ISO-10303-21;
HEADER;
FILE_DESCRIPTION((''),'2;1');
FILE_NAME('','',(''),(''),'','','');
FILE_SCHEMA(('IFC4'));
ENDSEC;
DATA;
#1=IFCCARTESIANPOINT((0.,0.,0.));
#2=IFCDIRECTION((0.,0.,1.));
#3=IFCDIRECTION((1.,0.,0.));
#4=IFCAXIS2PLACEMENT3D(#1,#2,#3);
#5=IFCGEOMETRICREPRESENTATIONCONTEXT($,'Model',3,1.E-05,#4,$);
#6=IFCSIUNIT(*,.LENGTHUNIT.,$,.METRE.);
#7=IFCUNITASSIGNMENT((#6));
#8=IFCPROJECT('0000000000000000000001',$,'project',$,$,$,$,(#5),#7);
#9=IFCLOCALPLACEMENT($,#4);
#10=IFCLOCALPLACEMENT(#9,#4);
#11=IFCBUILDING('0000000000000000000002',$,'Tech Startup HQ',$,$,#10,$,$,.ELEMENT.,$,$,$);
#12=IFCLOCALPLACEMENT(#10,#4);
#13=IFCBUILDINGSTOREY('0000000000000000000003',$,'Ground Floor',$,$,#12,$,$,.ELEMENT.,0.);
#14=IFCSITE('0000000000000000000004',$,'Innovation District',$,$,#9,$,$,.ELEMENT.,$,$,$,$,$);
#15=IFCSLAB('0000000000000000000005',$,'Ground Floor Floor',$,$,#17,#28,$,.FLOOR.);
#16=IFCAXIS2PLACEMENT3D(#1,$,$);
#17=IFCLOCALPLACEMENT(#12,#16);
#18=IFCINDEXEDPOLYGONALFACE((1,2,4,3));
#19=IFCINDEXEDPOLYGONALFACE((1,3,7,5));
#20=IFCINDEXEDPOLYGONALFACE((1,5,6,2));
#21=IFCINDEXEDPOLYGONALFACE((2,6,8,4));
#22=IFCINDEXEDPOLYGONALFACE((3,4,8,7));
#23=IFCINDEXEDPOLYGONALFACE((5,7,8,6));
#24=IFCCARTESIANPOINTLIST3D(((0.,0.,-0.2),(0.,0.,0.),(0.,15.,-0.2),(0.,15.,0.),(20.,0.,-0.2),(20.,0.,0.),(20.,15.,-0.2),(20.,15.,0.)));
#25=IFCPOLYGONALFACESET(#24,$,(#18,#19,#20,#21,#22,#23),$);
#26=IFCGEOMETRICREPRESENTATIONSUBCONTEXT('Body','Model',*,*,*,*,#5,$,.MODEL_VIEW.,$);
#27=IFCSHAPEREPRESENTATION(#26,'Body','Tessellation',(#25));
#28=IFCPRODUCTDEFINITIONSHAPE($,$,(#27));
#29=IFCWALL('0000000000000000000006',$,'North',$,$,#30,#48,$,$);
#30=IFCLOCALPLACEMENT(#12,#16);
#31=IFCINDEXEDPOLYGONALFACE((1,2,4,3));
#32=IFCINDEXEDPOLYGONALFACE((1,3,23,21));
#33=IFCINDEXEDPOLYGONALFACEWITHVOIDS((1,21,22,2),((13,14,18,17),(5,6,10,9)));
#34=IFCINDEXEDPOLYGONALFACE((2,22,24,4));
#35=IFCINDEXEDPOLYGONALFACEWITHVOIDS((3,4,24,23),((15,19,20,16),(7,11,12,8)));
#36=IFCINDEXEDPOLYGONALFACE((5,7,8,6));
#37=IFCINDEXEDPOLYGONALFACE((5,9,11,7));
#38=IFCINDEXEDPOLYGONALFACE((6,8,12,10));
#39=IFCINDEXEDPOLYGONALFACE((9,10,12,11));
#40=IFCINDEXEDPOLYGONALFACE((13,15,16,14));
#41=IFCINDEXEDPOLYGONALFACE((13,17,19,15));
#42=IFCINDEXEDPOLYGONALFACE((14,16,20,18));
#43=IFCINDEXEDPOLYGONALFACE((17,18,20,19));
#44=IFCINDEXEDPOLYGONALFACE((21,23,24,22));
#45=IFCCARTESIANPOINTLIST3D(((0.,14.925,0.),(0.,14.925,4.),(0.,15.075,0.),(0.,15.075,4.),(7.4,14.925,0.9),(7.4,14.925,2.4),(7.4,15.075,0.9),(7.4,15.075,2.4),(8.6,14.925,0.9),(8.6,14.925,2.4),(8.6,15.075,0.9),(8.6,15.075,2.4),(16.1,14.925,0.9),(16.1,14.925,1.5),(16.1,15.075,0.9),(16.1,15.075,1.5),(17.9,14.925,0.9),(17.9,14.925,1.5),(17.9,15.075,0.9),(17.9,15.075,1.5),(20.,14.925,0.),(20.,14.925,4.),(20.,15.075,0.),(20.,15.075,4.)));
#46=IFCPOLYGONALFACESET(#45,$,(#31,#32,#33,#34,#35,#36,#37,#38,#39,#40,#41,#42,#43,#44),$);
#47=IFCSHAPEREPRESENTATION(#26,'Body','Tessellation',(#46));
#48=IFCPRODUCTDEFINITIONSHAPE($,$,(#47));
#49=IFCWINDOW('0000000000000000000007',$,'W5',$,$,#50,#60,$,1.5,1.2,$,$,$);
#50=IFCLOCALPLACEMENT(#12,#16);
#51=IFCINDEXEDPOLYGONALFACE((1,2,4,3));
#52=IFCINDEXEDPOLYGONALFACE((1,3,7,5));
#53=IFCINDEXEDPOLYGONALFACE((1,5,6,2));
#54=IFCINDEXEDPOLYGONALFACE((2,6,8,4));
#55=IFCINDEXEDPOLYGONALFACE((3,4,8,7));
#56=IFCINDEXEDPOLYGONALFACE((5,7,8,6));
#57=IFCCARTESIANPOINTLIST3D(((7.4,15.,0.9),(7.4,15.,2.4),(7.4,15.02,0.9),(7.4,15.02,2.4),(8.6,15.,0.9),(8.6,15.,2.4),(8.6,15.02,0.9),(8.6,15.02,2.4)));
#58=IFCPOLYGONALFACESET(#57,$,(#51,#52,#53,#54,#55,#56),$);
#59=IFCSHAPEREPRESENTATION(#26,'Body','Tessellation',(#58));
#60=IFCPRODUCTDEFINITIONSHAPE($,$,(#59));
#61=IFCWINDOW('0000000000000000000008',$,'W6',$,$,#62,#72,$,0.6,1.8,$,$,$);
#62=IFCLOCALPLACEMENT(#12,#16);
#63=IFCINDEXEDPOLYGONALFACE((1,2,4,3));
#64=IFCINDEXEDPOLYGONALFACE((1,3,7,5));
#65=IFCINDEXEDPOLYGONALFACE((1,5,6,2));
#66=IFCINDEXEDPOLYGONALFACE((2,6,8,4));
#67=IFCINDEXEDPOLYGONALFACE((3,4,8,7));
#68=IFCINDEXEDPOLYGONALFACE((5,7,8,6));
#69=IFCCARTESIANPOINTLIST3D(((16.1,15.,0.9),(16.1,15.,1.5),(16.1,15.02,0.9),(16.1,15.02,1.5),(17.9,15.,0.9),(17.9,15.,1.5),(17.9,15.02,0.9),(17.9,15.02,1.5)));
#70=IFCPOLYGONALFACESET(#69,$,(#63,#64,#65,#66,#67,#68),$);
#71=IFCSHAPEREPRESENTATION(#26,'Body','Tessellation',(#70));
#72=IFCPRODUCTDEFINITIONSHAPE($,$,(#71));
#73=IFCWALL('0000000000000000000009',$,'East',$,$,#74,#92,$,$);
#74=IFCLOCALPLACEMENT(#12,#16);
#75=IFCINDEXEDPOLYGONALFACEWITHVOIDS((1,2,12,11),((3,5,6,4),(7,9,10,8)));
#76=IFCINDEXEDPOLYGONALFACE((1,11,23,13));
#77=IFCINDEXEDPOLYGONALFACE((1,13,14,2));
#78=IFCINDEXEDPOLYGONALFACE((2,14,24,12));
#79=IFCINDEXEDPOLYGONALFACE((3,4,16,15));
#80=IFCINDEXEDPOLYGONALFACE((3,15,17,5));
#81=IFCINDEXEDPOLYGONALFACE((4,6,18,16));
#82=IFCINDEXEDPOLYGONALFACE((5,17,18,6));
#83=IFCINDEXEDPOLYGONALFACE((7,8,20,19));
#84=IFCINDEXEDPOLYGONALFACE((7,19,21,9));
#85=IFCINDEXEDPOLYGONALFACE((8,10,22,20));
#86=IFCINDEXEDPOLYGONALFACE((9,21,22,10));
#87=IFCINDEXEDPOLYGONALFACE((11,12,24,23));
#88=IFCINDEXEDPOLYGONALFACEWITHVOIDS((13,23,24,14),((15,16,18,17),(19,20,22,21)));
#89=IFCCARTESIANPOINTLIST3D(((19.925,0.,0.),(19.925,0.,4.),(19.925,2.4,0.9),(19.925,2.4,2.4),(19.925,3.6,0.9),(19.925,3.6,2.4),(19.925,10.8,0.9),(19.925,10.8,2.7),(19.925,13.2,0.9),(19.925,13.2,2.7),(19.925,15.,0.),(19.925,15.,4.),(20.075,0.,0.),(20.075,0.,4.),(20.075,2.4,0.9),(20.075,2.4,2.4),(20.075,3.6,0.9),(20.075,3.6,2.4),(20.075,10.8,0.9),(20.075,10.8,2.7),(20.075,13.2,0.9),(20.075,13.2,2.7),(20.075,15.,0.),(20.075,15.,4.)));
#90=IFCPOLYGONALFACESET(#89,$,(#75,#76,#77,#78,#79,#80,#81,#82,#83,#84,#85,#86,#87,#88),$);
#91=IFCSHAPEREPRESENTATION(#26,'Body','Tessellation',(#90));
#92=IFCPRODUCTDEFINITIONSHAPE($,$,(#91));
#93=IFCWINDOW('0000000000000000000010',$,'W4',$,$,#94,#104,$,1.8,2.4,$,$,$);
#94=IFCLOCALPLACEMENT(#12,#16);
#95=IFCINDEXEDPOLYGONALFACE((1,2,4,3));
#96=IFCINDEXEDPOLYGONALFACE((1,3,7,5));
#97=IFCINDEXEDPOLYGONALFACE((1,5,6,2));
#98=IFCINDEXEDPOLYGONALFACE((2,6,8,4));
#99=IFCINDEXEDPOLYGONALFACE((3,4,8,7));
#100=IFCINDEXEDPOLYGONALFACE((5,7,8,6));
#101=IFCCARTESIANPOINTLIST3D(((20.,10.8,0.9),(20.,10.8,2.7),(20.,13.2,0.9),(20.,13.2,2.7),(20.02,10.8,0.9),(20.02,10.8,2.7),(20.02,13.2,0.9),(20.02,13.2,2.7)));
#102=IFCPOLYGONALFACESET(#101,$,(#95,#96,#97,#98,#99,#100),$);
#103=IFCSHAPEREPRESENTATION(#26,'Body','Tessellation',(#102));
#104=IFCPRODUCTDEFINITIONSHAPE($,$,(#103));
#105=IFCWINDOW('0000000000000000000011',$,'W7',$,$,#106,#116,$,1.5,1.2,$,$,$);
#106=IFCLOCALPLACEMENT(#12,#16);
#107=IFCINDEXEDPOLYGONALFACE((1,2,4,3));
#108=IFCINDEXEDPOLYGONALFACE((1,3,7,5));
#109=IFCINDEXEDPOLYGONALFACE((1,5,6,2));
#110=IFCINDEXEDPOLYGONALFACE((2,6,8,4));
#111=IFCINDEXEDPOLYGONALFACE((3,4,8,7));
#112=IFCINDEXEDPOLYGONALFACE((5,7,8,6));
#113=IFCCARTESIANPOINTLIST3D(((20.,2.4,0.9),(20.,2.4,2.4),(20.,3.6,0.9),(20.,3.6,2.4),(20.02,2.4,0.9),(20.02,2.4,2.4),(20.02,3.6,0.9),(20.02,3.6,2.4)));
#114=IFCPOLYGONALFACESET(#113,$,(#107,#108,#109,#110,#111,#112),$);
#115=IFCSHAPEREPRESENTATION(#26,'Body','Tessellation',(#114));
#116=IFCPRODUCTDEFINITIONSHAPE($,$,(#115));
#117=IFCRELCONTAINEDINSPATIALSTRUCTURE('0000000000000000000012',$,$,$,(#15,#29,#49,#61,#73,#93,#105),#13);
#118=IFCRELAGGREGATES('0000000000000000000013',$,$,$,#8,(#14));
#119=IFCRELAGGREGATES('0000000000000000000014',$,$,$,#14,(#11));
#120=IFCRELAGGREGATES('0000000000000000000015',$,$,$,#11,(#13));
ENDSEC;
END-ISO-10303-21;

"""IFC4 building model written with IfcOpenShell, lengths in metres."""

from ifc_helpers import new_model, si_unit, origin_with_axes, place, context, subcontext, project, spatial, polyline, outline, extrude, element, fill, save


model = new_model("IFC4")

# Units and contexts
model_context = context("Model", 3, precision=1e-05, world=origin_with_axes())
body_context = subcontext(model_context, "Body", "Model", "MODEL_VIEW")
ifc_project = project(units=[si_unit("LENGTHUNIT", "METRE")], contexts=[model_context])

# Site, building, storey
site_placement = place(None, origin_with_axes())
site = spatial("IfcSite", under=ifc_project, at=site_placement, Name="Innovation District", CompositionType="ELEMENT")
building_placement = place(site_placement, origin_with_axes())
building = spatial("IfcBuilding", under=site, at=building_placement, Name="Tech Startup HQ", CompositionType="ELEMENT")
storey_placement = place(building_placement, origin_with_axes())
storey = spatial("IfcBuildingStorey", under=building, at=storey_placement, Name="Ground Floor", CompositionType="ELEMENT", Elevation=0.0)

# Slab
slab_placement = place(storey_placement, origin_with_axes())
element("IfcSlab", 1, at=slab_placement, inside=storey, Name="Ground Floor Floor", PredefinedType="FLOOR", context=body_context, shape_type="SweptSolid", body=[
    extrude(outline(polyline([(0.0, 0.0, -0.2), (20.0, 0.0, -0.2), (20.0, 15.0, -0.2), (0.0, 15.0, -0.2), (0.0, 0.0, -0.2)])), None, (0.0, 0.0, 1.0), 0.2),
])

# Walls, openings, windows
wall_1_placement = place(storey_placement, origin_with_axes())
wall_1 = element("IfcWall", 2, at=wall_1_placement, inside=storey, Name="North", context=body_context, shape_type="SweptSolid", body=[
    extrude(outline(polyline([(0.0, 14.925, 0.0), (20.0, 14.925, 0.0), (20.0, 15.075, 0.0), (0.0, 15.075, 0.0), (0.0, 14.925, 0.0)])), None, (0.0, 0.0, 1.0), 4.0),
])
opening_1_placement = place(storey_placement, origin_with_axes())
opening_1 = element("IfcOpeningElement", 3, at=opening_1_placement, inside=storey, cuts=wall_1, context=body_context, shape_type="SweptSolid", body=[
    extrude(outline(polyline([(7.4, 14.85, 0.9), (8.6, 14.85, 0.9), (8.6, 15.15, 0.9), (7.4, 15.15, 0.9), (7.4, 14.85, 0.9)])), None, (0.0, 0.0, 1.0), 1.5),
])
opening_2_placement = place(storey_placement, origin_with_axes())
opening_2 = element("IfcOpeningElement", 4, at=opening_2_placement, inside=storey, cuts=wall_1, context=body_context, shape_type="SweptSolid", body=[
    extrude(outline(polyline([(16.1, 14.85, 0.9), (17.9, 14.85, 0.9), (17.9, 15.15, 0.9), (16.1, 15.15, 0.9), (16.1, 14.85, 0.9)])), None, (0.0, 0.0, 1.0), 0.6),
])
window_1_placement = place(storey_placement, origin_with_axes())
window_1 = element("IfcWindow", 5, at=window_1_placement, inside=storey, Name="W5", OverallHeight=1.5, OverallWidth=1.2, context=body_context, shape_type="SweptSolid", body=[
    extrude(outline(polyline([(7.4, 15.0, 0.9), (8.6, 15.0, 0.9), (8.6, 15.02, 0.9), (7.4, 15.02, 0.9), (7.4, 15.0, 0.9)])), None, (0.0, 0.0, 1.0), 1.5),
])
fill(opening_1, window_1)
window_2_placement = place(storey_placement, origin_with_axes())
window_2 = element("IfcWindow", 6, at=window_2_placement, inside=storey, Name="W6", OverallHeight=0.6, OverallWidth=1.8, context=body_context, shape_type="SweptSolid", body=[
    extrude(outline(polyline([(16.1, 15.0, 0.9), (17.9, 15.0, 0.9), (17.9, 15.02, 0.9), (16.1, 15.02, 0.9), (16.1, 15.0, 0.9)])), None, (0.0, 0.0, 1.0), 0.6),
])
fill(opening_2, window_2)
wall_2_placement = place(storey_placement, origin_with_axes())
wall_2 = element("IfcWall", 7, at=wall_2_placement, inside=storey, Name="East", context=body_context, shape_type="SweptSolid", body=[
    extrude(outline(polyline([(19.925, 15.0, 0.0), (19.925, 0.0, 0.0), (20.075, 0.0, 0.0), (20.075, 15.0, 0.0), (19.925, 15.0, 0.0)])), None, (0.0, 0.0, 1.0), 4.0),
])
opening_3_placement = place(storey_placement, origin_with_axes())
opening_3 = element("IfcOpeningElement", 8, at=opening_3_placement, inside=storey, cuts=wall_2, context=body_context, shape_type="SweptSolid", body=[
    extrude(outline(polyline([(19.85, 13.2, 0.9), (19.85, 10.8, 0.9), (20.15, 10.8, 0.9), (20.15, 13.2, 0.9), (19.85, 13.2, 0.9)])), None, (0.0, 0.0, 1.0), 1.8),
])
opening_4_placement = place(storey_placement, origin_with_axes())
opening_4 = element("IfcOpeningElement", 9, at=opening_4_placement, inside=storey, cuts=wall_2, context=body_context, shape_type="SweptSolid", body=[
    extrude(outline(polyline([(19.85, 3.6, 0.9), (19.85, 2.4, 0.9), (20.15, 2.4, 0.9), (20.15, 3.6, 0.9), (19.85, 3.6, 0.9)])), None, (0.0, 0.0, 1.0), 1.5),
])
window_3_placement = place(storey_placement, origin_with_axes())
window_3 = element("IfcWindow", 10, at=window_3_placement, inside=storey, Name="W4", OverallHeight=1.8, OverallWidth=2.4, context=body_context, shape_type="SweptSolid", body=[
    extrude(outline(polyline([(20.0, 13.2, 0.9), (20.0, 10.8, 0.9), (20.02, 10.8, 0.9), (20.02, 13.2, 0.9), (20.0, 13.2, 0.9)])), None, (0.0, 0.0, 1.0), 1.8),
])
fill(opening_3, window_3)
window_4_placement = place(storey_placement, origin_with_axes())
window_4 = element("IfcWindow", 11, at=window_4_placement, inside=storey, Name="W7", OverallHeight=1.5, OverallWidth=1.2, context=body_context, shape_type="SweptSolid", body=[
    extrude(outline(polyline([(20.0, 3.6, 0.9), (20.0, 2.4, 0.9), (20.02, 2.4, 0.9), (20.02, 3.6, 0.9), (20.0, 3.6, 0.9)])), None, (0.0, 0.0, 1.0), 1.5),
])
fill(opening_4, window_4)

save(model, "model.ifc")
